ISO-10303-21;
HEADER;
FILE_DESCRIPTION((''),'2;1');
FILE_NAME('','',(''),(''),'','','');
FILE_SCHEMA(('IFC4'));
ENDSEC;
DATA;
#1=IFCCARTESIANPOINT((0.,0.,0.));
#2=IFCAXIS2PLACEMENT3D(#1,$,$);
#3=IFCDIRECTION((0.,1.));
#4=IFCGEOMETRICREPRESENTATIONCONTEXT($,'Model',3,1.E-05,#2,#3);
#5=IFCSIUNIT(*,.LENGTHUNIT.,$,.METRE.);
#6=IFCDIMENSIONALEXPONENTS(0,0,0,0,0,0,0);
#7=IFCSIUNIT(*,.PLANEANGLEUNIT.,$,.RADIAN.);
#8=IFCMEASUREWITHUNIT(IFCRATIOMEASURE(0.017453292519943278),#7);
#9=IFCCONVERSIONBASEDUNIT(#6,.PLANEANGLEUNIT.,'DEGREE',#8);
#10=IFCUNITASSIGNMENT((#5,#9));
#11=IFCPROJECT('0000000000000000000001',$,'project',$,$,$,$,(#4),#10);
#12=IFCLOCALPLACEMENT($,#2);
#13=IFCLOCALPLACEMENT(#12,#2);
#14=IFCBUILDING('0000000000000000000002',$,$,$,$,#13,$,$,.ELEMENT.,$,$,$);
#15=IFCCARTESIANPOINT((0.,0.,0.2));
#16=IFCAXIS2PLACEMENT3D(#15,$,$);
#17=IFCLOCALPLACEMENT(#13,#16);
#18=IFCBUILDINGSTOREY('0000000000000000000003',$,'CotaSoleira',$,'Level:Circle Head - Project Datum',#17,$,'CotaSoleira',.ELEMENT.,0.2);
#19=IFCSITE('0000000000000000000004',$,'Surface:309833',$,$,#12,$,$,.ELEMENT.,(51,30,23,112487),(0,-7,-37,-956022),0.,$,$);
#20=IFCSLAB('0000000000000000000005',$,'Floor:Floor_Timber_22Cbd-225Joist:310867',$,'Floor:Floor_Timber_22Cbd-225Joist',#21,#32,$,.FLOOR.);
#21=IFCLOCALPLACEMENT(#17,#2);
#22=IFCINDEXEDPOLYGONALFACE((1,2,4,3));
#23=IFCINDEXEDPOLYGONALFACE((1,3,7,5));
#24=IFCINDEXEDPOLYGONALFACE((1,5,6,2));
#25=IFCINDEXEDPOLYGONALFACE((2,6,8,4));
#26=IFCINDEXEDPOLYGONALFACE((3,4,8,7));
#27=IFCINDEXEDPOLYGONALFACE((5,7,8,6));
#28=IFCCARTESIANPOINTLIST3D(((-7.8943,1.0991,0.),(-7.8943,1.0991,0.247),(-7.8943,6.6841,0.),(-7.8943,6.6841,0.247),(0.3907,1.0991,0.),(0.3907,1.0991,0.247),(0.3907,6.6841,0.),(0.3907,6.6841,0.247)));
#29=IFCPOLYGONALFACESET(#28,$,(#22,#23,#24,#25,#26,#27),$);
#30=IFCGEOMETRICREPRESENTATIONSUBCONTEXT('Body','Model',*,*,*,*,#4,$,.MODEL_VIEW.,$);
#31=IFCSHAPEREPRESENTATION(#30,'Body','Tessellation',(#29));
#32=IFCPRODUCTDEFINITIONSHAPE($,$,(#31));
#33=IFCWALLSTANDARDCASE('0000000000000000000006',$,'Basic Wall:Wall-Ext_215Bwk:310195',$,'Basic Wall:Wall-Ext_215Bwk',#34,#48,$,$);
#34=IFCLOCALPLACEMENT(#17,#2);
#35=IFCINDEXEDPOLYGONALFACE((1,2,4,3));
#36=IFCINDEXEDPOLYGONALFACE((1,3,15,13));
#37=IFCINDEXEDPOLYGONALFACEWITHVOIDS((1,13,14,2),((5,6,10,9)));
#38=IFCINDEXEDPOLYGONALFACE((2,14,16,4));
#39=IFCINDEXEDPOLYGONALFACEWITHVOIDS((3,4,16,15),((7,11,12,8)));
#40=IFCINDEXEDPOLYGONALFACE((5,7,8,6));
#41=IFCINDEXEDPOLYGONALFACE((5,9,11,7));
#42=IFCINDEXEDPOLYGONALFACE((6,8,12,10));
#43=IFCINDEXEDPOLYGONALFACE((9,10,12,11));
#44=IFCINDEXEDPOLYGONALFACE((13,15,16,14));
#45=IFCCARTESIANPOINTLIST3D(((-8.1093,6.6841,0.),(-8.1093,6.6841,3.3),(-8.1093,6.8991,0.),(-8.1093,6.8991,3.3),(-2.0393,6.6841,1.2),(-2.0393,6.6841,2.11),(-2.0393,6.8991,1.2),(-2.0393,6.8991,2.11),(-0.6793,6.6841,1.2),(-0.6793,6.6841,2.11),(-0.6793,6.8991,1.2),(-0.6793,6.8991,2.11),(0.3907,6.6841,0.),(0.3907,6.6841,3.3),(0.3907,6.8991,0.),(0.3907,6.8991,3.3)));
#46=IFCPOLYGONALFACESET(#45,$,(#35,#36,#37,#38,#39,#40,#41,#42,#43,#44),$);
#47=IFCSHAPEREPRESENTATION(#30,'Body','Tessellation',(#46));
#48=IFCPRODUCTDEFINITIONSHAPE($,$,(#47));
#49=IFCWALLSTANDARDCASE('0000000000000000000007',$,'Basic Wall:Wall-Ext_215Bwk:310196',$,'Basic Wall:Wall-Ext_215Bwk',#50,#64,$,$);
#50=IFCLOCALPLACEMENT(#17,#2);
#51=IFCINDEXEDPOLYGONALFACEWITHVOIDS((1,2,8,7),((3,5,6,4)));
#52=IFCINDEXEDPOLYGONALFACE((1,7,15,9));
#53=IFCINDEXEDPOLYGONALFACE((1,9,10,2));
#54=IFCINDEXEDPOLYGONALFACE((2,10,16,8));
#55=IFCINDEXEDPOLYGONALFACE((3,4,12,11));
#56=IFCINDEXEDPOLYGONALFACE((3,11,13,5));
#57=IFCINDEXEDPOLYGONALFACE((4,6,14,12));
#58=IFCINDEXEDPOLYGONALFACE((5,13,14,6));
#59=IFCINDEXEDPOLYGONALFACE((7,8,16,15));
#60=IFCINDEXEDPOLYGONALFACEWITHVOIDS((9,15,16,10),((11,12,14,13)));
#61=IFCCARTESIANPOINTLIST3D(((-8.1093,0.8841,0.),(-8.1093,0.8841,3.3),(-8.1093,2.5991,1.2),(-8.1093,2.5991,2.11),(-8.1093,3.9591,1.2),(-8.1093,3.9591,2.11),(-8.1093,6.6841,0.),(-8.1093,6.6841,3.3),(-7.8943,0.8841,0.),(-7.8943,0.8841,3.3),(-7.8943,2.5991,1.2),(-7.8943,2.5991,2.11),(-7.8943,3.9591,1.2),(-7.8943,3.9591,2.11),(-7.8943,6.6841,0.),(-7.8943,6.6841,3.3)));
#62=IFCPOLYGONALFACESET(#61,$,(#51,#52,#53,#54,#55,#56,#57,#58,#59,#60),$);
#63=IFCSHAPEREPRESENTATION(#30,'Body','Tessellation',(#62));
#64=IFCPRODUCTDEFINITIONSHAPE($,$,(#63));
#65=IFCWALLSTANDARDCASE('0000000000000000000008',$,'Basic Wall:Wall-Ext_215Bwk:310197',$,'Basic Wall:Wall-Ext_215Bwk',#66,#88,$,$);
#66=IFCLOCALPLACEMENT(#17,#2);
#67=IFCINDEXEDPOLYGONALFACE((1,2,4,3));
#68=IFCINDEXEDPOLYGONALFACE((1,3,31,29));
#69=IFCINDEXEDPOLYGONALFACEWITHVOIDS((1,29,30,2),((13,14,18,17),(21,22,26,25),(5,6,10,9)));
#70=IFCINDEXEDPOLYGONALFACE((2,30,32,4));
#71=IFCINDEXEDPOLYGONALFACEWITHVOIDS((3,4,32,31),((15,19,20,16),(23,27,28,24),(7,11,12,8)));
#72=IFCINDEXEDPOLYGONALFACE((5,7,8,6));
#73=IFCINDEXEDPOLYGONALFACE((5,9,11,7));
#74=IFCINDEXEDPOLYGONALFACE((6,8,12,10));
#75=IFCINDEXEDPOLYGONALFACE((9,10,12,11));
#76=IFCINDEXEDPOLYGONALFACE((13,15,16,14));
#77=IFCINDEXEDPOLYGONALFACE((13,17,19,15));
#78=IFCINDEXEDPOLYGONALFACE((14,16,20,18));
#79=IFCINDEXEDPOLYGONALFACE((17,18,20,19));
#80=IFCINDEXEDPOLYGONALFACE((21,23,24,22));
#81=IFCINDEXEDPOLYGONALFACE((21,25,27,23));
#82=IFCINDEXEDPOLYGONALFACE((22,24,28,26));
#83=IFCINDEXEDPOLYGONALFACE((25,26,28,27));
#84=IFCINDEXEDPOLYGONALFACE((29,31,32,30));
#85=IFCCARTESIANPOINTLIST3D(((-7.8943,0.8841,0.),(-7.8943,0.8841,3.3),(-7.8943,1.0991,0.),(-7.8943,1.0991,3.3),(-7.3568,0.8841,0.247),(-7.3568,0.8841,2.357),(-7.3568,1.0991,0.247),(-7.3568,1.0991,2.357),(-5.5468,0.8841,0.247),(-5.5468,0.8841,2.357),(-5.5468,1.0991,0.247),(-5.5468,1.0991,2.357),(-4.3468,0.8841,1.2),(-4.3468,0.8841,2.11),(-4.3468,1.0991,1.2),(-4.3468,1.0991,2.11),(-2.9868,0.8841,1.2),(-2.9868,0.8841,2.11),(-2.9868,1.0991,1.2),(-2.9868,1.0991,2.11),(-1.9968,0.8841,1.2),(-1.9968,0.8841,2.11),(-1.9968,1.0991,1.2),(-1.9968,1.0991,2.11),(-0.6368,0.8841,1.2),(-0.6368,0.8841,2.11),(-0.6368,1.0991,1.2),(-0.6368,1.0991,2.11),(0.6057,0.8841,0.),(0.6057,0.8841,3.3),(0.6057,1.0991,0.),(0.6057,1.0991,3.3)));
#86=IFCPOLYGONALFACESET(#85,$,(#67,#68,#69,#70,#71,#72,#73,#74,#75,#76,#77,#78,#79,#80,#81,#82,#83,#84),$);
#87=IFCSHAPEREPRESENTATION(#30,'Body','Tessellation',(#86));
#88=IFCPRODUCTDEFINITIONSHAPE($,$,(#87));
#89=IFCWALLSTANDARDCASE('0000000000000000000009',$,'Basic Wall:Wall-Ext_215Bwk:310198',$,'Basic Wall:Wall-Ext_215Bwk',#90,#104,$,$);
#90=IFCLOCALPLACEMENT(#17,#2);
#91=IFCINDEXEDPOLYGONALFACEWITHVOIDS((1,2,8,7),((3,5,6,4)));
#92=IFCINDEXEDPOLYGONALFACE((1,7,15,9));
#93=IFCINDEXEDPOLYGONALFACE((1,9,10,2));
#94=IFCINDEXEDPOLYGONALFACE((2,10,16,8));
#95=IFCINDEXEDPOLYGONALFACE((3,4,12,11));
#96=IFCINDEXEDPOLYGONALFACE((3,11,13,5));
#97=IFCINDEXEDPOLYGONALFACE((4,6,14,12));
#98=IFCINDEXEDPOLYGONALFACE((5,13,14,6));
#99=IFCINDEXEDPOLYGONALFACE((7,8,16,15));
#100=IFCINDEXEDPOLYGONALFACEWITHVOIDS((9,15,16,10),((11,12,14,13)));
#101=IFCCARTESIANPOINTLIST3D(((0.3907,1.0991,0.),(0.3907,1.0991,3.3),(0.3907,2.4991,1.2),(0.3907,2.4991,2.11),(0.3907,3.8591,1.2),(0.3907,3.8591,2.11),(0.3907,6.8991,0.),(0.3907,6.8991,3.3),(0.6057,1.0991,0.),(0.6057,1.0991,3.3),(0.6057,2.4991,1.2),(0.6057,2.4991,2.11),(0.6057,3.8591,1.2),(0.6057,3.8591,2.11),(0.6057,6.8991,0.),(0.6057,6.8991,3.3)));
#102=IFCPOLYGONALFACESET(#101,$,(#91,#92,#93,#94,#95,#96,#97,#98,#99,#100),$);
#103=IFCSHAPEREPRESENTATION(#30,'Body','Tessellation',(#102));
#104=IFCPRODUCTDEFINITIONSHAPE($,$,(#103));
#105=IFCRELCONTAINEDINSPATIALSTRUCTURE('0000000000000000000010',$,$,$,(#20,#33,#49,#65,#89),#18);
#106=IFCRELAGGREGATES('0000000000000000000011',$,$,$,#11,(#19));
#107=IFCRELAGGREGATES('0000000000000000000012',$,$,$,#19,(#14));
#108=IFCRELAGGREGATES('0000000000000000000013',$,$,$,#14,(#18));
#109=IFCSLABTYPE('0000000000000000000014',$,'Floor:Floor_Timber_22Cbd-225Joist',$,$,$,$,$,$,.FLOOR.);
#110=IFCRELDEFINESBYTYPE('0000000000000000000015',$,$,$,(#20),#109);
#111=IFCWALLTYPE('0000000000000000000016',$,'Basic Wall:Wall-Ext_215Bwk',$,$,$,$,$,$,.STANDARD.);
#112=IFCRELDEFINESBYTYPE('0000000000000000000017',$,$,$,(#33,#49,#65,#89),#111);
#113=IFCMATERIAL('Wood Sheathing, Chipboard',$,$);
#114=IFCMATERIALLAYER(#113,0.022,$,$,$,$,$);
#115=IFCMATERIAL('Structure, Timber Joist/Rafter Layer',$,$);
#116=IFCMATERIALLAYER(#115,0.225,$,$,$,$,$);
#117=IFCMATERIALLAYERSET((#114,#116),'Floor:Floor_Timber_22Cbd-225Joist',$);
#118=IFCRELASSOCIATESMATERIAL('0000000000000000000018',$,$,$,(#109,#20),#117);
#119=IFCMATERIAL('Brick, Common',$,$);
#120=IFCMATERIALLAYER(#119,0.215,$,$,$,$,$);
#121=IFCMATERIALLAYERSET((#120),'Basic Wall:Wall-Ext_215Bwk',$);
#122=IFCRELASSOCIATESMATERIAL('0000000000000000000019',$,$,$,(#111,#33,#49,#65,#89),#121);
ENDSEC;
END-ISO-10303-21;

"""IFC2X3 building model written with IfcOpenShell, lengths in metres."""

from ifc_helpers import new_model, entity, si_unit, converted_unit, direction, frame, frame_2d, origin, origin_2d_with_axis, place, context, subcontext, project, spatial, rectangle, extrude, material, layer, layer_set, layer_usage, type_object, element, save


model = new_model("IFC2X3")

# Units and contexts
model_context = context("Model", 3, precision=1e-05, world=origin(), true_north=direction((0.0, 1.0)))
body_context = subcontext(model_context, "Body", "Model", "MODEL_VIEW")
ifc_project = project(units=[si_unit("LENGTHUNIT", "METRE"), converted_unit("PLANEANGLEUNIT", "DEGREE", entity("IfcRatioMeasure", 0.017453292519943278), si_unit("PLANEANGLEUNIT", "RADIAN"), dimensions=[0, 0, 0, 0, 0, 0, 0])], contexts=[model_context])

# Site, building, storey
site_placement = place(None, origin())
site = spatial("IfcSite", under=ifc_project, at=site_placement, Name="Surface:309833", CompositionType="ELEMENT", RefLatitude=(51, 30, 23, 112487), RefLongitude=(0, -7, -37, -956022), RefElevation=0.0)
building_placement = place(site_placement, origin())
building = spatial("IfcBuilding", under=site, at=building_placement, CompositionType="ELEMENT")
storey_placement = place(building_placement, frame((0.0, 0.0, 0.2)))
storey = spatial("IfcBuildingStorey", under=building, at=storey_placement, Name="CotaSoleira", ObjectType="Level:Circle Head - Project Datum", LongName="CotaSoleira", CompositionType="ELEMENT", Elevation=0.2)

# Slab
ifc_material_1 = material(Name="Wood Sheathing, Chipboard")
ifc_layer_1 = layer(ifc_material_1, 0.022)
ifc_material_2 = material(Name="Structure, Timber Joist/Rafter Layer")
ifc_layer_2 = layer(ifc_material_2, 0.225)
ifc_layer_set_1 = layer_set([ifc_layer_1, ifc_layer_2], Name="Floor:Floor_Timber_22Cbd-225Joist")
ifc_layer_usage_1 = layer_usage(ifc_layer_set_1, "AXIS3", "POSITIVE", 0.0)
slab_type = type_object("IfcSlabType", Name="Floor:Floor_Timber_22Cbd-225Joist", PredefinedType="FLOOR", material=ifc_layer_set_1)
slab_placement = place(storey_placement, origin())
element("IfcSlab", 1, at=slab_placement, inside=storey, type_object=slab_type, material=ifc_layer_usage_1, Name="Floor:Floor_Timber_22Cbd-225Joist:310867", ObjectType="Floor:Floor_Timber_22Cbd-225Joist", PredefinedType="FLOOR", context=body_context, shape_type="SweptSolid", body=[
    extrude(rectangle(XDim=5.585, YDim=8.285, at=origin_2d_with_axis()), frame((-3.7518, 3.8916, 0.247), z_axis=(0.0, 0.0, -1.0), x_axis=(0.0, 1.0, 0.0)), (0.0, 0.0, 1.0), 0.247),
])

# Walls, openings
ifc_material_3 = material(Name="Brick, Common")
ifc_layer_3 = layer(ifc_material_3, 0.215)
ifc_layer_set_2 = layer_set([ifc_layer_3], Name="Basic Wall:Wall-Ext_215Bwk")
ifc_layer_usage_2 = layer_usage(ifc_layer_set_2, "AXIS2", "NEGATIVE", 0.1075)
wall_type = type_object("IfcWallType", Name="Basic Wall:Wall-Ext_215Bwk", PredefinedType="STANDARD", material=ifc_layer_set_2)
wall_1_placement = place(storey_placement, frame((-8.1093, 6.7916, 0.0)))
wall_1 = element("IfcWallStandardCase", 2, at=wall_1_placement, inside=storey, type_object=wall_type, material=ifc_layer_usage_2, Name="Basic Wall:Wall-Ext_215Bwk:310195", ObjectType="Basic Wall:Wall-Ext_215Bwk", context=body_context, shape_type="SweptSolid", body=[
    extrude(rectangle(XDim=8.5, YDim=0.215, at=frame_2d((4.25, 0.0), x_axis=(-1.0, 0.0))), origin(), (0.0, 0.0, 1.0), 3.3),
])
opening_1_placement = place(wall_1_placement, frame((7.43, 0.1075, 1.2)))
element("IfcOpeningElement", 3, at=opening_1_placement, cuts=wall_1, ObjectType="Opening", context=body_context, shape_type="SweptSolid", body=[
    extrude(rectangle(XDim=0.91, YDim=1.36, at=frame_2d((0.455, 0.68), x_axis=(-1.0, 0.0))), frame((0.0, 0.0, 0.0), z_axis=(0.0, -1.0, 0.0), x_axis=(0.0, 0.0, 1.0)), (0.0, 0.0, 1.0), 0.215),
])
wall_2_placement = place(storey_placement, frame((-8.0018, 0.8841, 0.0), z_axis=(0.0, 0.0, 1.0), x_axis=(0.0, 1.0, 0.0)))
wall_2 = element("IfcWallStandardCase", 4, at=wall_2_placement, inside=storey, type_object=wall_type, material=ifc_layer_usage_2, Name="Basic Wall:Wall-Ext_215Bwk:310196", ObjectType="Basic Wall:Wall-Ext_215Bwk", context=body_context, shape_type="SweptSolid", body=[
    extrude(rectangle(XDim=5.8, YDim=0.215, at=frame_2d((2.9, 0.0), x_axis=(-1.0, 0.0))), origin(), (0.0, 0.0, 1.0), 3.3),
])
opening_2_placement = place(wall_2_placement, frame((3.075, 0.1075, 1.2)))
element("IfcOpeningElement", 5, at=opening_2_placement, cuts=wall_2, ObjectType="Opening", context=body_context, shape_type="SweptSolid", body=[
    extrude(rectangle(XDim=0.91, YDim=1.36, at=frame_2d((0.455, 0.68), x_axis=(-1.0, 0.0))), frame((0.0, 0.0, 0.0), z_axis=(0.0, -1.0, 0.0), x_axis=(0.0, 0.0, 1.0)), (0.0, 0.0, 1.0), 0.215),
])

# Wall, openings
wall_3_placement = place(storey_placement, frame((0.6057, 0.9916, 0.0), z_axis=(0.0, 0.0, 1.0), x_axis=(-1.0, 0.0, 0.0)))
wall_3 = element("IfcWallStandardCase", 6, at=wall_3_placement, inside=storey, type_object=wall_type, material=ifc_layer_usage_2, Name="Basic Wall:Wall-Ext_215Bwk:310197", ObjectType="Basic Wall:Wall-Ext_215Bwk", context=body_context, shape_type="SweptSolid", body=[
    extrude(rectangle(XDim=8.5, YDim=0.215, at=frame_2d((4.25, 0.0), x_axis=(-1.0, 0.0))), origin(), (0.0, 0.0, 1.0), 3.3),
])
opening_3_placement = place(wall_3_placement, frame((7.9625, 0.1075, 0.247)))
element("IfcOpeningElement", 7, at=opening_3_placement, cuts=wall_3, ObjectType="Opening", context=body_context, shape_type="SweptSolid", body=[
    extrude(rectangle(XDim=2.11, YDim=1.81, at=frame_2d((1.055, 0.905), x_axis=(-1.0, 0.0))), frame((0.0, 0.0, 0.0), z_axis=(0.0, -1.0, 0.0), x_axis=(0.0, 0.0, 1.0)), (0.0, 0.0, 1.0), 0.215),
])
opening_4_placement = place(wall_3_placement, frame((4.9525, 0.1075, 1.2)))
element("IfcOpeningElement", 8, at=opening_4_placement, cuts=wall_3, ObjectType="Opening", context=body_context, shape_type="SweptSolid", body=[
    extrude(rectangle(XDim=0.91, YDim=1.36, at=frame_2d((0.455, 0.68), x_axis=(-1.0, 0.0))), frame((0.0, 0.0, 0.0), z_axis=(0.0, -1.0, 0.0), x_axis=(0.0, 0.0, 1.0)), (0.0, 0.0, 1.0), 0.215),
])
opening_5_placement = place(wall_3_placement, frame((2.6025, 0.1075, 1.2)))
element("IfcOpeningElement", 9, at=opening_5_placement, cuts=wall_3, ObjectType="Opening", context=body_context, shape_type="SweptSolid", body=[
    extrude(rectangle(XDim=0.91, YDim=1.36, at=frame_2d((0.455, 0.68), x_axis=(-1.0, 0.0))), frame((0.0, 0.0, 0.0), z_axis=(0.0, -1.0, 0.0), x_axis=(0.0, 0.0, 1.0)), (0.0, 0.0, 1.0), 0.215),
])

# Wall, opening
wall_4_placement = place(storey_placement, frame((0.4982, 6.8991, 0.0), z_axis=(0.0, 0.0, 1.0), x_axis=(0.0, -1.0, 0.0)))
wall_4 = element("IfcWallStandardCase", 10, at=wall_4_placement, inside=storey, type_object=wall_type, material=ifc_layer_usage_2, Name="Basic Wall:Wall-Ext_215Bwk:310198", ObjectType="Basic Wall:Wall-Ext_215Bwk", context=body_context, shape_type="SweptSolid", body=[
    extrude(rectangle(XDim=5.8, YDim=0.215, at=frame_2d((2.9, 0.0), x_axis=(-1.0, 0.0))), origin(), (0.0, 0.0, 1.0), 3.3),
])
opening_6_placement = place(wall_4_placement, frame((4.4, 0.1075, 1.2)))
element("IfcOpeningElement", 11, at=opening_6_placement, cuts=wall_4, ObjectType="Opening", context=body_context, shape_type="SweptSolid", body=[
    extrude(rectangle(XDim=0.91, YDim=1.36, at=frame_2d((0.455, 0.68), x_axis=(-1.0, 0.0))), frame((0.0, 0.0, 0.0), z_axis=(0.0, -1.0, 0.0), x_axis=(0.0, 0.0, 1.0)), (0.0, 0.0, 1.0), 0.215),
])

save(model, "model.ifc")
